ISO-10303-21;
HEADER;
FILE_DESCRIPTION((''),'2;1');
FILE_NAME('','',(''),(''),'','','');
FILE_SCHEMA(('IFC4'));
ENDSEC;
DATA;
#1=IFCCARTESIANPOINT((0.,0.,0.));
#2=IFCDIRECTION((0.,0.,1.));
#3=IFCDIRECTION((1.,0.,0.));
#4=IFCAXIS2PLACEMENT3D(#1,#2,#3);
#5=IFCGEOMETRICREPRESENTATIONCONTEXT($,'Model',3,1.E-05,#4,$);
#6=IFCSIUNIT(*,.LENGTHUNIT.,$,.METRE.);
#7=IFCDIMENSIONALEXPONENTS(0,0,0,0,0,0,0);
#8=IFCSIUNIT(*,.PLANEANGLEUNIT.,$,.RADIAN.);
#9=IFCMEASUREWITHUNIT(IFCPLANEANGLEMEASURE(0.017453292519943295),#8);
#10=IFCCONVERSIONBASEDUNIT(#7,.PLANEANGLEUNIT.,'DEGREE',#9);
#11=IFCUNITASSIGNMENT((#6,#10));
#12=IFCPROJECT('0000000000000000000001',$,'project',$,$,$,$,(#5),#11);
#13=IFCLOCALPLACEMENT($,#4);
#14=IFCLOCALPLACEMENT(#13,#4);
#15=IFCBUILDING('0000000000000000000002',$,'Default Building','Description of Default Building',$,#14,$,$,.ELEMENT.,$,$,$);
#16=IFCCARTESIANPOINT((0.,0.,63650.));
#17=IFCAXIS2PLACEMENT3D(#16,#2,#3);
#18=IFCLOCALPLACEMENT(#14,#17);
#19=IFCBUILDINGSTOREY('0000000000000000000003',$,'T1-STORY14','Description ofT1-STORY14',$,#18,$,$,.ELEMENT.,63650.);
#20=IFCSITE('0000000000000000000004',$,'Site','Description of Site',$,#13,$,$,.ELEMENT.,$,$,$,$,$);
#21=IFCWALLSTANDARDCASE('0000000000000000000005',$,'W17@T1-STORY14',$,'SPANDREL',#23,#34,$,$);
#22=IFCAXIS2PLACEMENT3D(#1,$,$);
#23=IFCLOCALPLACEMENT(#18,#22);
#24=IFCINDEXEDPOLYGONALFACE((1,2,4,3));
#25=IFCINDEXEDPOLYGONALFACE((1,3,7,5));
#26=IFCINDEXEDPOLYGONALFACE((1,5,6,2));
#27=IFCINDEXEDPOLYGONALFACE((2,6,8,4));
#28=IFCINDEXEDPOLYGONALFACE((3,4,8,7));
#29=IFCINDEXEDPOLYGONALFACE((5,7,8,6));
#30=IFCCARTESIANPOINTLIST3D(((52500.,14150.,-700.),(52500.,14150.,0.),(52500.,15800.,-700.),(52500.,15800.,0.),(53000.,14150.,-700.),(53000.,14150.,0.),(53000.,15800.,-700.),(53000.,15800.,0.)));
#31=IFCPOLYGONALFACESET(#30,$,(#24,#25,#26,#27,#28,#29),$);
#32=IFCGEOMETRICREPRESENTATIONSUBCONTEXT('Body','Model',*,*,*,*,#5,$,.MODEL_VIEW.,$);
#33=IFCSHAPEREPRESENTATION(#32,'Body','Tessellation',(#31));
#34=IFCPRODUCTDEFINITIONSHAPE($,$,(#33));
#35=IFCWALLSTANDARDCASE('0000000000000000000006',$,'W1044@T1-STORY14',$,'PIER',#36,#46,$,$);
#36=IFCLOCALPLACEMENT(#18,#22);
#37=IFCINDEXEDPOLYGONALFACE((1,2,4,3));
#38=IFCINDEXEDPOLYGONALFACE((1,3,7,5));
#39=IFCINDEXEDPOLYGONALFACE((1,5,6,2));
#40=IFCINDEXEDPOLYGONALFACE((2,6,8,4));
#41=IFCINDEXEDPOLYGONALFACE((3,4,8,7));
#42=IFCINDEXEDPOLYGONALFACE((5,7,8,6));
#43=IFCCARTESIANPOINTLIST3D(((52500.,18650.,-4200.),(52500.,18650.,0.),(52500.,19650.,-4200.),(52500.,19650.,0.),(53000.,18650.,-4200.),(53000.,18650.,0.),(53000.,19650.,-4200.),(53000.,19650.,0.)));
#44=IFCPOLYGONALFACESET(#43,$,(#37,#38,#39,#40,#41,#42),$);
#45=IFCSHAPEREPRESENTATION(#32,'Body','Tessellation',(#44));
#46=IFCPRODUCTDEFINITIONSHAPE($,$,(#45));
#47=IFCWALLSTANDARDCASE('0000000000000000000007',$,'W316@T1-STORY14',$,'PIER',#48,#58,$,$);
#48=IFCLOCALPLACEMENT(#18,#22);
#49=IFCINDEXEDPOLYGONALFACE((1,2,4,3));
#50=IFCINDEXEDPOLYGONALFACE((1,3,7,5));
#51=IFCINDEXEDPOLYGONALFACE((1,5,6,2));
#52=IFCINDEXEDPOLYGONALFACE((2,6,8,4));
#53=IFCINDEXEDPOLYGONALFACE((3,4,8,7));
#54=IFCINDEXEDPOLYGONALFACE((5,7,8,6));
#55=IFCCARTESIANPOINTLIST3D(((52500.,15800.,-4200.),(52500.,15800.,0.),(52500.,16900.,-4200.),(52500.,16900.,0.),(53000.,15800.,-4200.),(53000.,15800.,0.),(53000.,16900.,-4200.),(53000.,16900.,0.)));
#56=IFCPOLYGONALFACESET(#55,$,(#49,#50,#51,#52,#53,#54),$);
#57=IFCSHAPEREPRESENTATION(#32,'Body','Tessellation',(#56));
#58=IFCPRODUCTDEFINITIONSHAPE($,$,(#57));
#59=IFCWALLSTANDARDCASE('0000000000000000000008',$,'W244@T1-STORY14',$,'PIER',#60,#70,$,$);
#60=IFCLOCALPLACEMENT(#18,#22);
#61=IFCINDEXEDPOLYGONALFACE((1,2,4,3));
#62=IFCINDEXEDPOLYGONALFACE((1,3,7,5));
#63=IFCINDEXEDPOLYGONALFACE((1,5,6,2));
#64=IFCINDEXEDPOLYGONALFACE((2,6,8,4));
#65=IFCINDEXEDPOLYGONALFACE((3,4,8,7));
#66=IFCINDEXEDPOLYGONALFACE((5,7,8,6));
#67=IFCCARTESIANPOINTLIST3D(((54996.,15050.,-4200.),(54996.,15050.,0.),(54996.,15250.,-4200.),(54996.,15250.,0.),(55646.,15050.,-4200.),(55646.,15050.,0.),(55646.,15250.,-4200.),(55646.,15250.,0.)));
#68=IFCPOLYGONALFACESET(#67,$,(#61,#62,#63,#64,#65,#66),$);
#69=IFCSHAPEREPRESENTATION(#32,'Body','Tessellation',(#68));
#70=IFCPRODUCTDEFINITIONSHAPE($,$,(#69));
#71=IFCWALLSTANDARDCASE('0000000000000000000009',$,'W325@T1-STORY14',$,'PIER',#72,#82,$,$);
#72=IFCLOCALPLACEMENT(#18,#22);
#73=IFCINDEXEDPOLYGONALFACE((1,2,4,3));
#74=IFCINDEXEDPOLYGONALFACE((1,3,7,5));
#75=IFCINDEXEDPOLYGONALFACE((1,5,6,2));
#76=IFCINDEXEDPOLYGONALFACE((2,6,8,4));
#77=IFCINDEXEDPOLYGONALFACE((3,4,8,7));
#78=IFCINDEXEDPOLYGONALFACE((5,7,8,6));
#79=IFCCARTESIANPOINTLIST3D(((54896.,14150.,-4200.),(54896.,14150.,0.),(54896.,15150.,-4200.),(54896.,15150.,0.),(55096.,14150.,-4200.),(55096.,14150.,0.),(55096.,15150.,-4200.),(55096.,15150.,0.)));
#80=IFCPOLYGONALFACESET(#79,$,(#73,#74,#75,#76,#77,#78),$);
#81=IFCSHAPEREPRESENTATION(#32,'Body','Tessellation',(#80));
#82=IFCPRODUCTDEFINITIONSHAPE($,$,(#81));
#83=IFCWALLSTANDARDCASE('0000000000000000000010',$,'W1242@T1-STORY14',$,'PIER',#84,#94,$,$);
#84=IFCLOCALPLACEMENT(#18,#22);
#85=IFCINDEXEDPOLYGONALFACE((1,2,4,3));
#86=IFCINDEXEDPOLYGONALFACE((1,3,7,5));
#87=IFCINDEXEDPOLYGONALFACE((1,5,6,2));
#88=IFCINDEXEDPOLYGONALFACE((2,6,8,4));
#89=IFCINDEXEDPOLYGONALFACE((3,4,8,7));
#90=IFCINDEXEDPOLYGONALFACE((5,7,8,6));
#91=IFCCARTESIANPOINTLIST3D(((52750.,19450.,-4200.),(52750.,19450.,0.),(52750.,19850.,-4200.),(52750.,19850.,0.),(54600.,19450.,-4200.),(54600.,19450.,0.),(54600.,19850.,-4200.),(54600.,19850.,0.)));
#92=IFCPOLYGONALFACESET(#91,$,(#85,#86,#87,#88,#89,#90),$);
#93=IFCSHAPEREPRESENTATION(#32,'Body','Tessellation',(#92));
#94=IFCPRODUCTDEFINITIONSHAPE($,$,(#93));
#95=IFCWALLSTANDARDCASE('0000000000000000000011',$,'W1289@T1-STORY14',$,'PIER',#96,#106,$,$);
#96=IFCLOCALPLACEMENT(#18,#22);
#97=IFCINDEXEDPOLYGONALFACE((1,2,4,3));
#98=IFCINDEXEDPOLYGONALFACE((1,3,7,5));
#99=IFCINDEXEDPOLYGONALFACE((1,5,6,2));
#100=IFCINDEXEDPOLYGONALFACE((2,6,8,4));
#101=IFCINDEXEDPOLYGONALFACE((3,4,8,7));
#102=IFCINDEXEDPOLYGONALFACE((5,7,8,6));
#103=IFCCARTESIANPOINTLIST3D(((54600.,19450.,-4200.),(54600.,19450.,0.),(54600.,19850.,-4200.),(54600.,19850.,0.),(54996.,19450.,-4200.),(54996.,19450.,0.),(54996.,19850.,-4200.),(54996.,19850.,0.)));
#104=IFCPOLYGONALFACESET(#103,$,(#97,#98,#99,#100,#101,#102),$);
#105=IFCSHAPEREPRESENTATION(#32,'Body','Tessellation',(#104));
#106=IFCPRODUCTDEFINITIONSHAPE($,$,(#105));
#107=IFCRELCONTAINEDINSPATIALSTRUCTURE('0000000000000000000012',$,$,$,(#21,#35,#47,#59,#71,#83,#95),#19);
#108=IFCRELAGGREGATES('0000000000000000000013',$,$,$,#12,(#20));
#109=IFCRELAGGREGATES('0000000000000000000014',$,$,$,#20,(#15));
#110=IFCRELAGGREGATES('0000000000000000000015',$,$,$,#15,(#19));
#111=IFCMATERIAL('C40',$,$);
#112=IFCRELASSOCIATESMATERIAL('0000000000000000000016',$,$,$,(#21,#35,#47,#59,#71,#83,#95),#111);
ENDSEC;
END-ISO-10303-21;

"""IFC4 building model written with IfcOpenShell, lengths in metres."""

from ifc_helpers import new_model, entity, si_unit, converted_unit, frame, origin_with_axes, place, context, subcontext, project, spatial, indexed_curve, outline, extrude, material, element, save


model = new_model("IFC4")

# Units and contexts
model_context = context("Model", 3, precision=1e-05, world=origin_with_axes())
body_context = subcontext(model_context, "Body", "Model", "MODEL_VIEW")
ifc_project = project(units=[si_unit("LENGTHUNIT", "METRE"), converted_unit("PLANEANGLEUNIT", "DEGREE", entity("IfcPlaneAngleMeasure", 0.017453292519943295), si_unit("PLANEANGLEUNIT", "RADIAN"), dimensions=[0, 0, 0, 0, 0, 0, 0])], contexts=[model_context])

# Site, building, storey
site_placement = place(None, origin_with_axes())
site = spatial("IfcSite", under=ifc_project, at=site_placement, Name="Site", Description="Description of Site", CompositionType="ELEMENT")
building_placement = place(site_placement, origin_with_axes())
building = spatial("IfcBuilding", under=site, at=building_placement, Name="Default Building", Description="Description of Default Building", CompositionType="ELEMENT")
storey_placement = place(building_placement, frame((0.0, 0.0, 63650.0), z_axis=(0.0, 0.0, 1.0), x_axis=(1.0, 0.0, 0.0)))
storey = spatial("IfcBuildingStorey", under=building, at=storey_placement, Name="T1-STORY14", Description="Description ofT1-STORY14", CompositionType="ELEMENT", Elevation=63650.0)

# Shared definitions
ifc_material_1 = material(Name="C40")

# Walls
wall_1_placement = place(storey_placement, frame((52750.0, 14150.0, -700.0), z_axis=(0.0, 0.0, 1.0), x_axis=(0.0, 1.0, 0.0)))
element("IfcWallStandardCase", 1, at=wall_1_placement, inside=storey, material=ifc_material_1, Name="W17@T1-STORY14", ObjectType="SPANDREL", context=body_context, shape_type="SweptSolid", body=[
    extrude(outline(indexed_curve([(0.0, -250.0), (0.0, 250.0), (1650.0, 250.0), (1650.0, -250.0), (0.0, -250.0)], self_intersect=False)), origin_with_axes(), (0.0, 0.0, 1.0), 700.0),
])
wall_2_placement = place(storey_placement, frame((52750.0, 18650.0, -4200.0), z_axis=(0.0, 0.0, 1.0), x_axis=(0.0, 1.0, 0.0)))
element("IfcWallStandardCase", 2, at=wall_2_placement, inside=storey, material=ifc_material_1, Name="W1044@T1-STORY14", ObjectType="PIER", context=body_context, shape_type="SweptSolid", body=[
    extrude(outline(indexed_curve([(0.0, -250.0), (0.0, 250.0), (1000.0, 250.0), (1000.0, -250.0), (0.0, -250.0)], self_intersect=False)), origin_with_axes(), (0.0, 0.0, 1.0), 4200.0),
])
wall_3_placement = place(storey_placement, frame((52750.0, 15800.0, -4200.0), z_axis=(0.0, 0.0, 1.0), x_axis=(0.0, 1.0, 0.0)))
element("IfcWallStandardCase", 3, at=wall_3_placement, inside=storey, material=ifc_material_1, Name="W316@T1-STORY14", ObjectType="PIER", context=body_context, shape_type="SweptSolid", body=[
    extrude(outline(indexed_curve([(0.0, -250.0), (0.0, 250.0), (1100.0, 250.0), (1100.0, -250.0), (0.0, -250.0)], self_intersect=False)), origin_with_axes(), (0.0, 0.0, 1.0), 4200.0),
])
wall_4_placement = place(storey_placement, frame((54996.0, 15150.0, -4200.0), z_axis=(0.0, 0.0, 1.0), x_axis=(1.0, 0.0, 0.0)))
element("IfcWallStandardCase", 4, at=wall_4_placement, inside=storey, material=ifc_material_1, Name="W244@T1-STORY14", ObjectType="PIER", context=body_context, shape_type="SweptSolid", body=[
    extrude(outline(indexed_curve([(0.0, -100.0), (0.0, 100.0), (650.0, 100.0), (650.0, -100.0), (0.0, -100.0)], self_intersect=False)), origin_with_axes(), (0.0, 0.0, 1.0), 4200.0),
])
wall_5_placement = place(storey_placement, frame((54996.0, 14150.0, -4200.0), z_axis=(0.0, 0.0, 1.0), x_axis=(0.0, 1.0, 0.0)))
element("IfcWallStandardCase", 5, at=wall_5_placement, inside=storey, material=ifc_material_1, Name="W325@T1-STORY14", ObjectType="PIER", context=body_context, shape_type="SweptSolid", body=[
    extrude(outline(indexed_curve([(0.0, -100.0), (0.0, 100.0), (1000.0, 100.0), (1000.0, -100.0), (0.0, -100.0)], self_intersect=False)), origin_with_axes(), (0.0, 0.0, 1.0), 4200.0),
])
wall_6_placement = place(storey_placement, frame((52750.0, 19650.0, -4200.0), z_axis=(0.0, 0.0, 1.0), x_axis=(1.0, 0.0, 0.0)))
element("IfcWallStandardCase", 6, at=wall_6_placement, inside=storey, material=ifc_material_1, Name="W1242@T1-STORY14", ObjectType="PIER", context=body_context, shape_type="SweptSolid", body=[
    extrude(outline(indexed_curve([(0.0, -200.0), (0.0, 200.0), (1850.0, 200.0), (1850.0, -200.0), (0.0, -200.0)], self_intersect=False)), origin_with_axes(), (0.0, 0.0, 1.0), 4200.0),
])
wall_7_placement = place(storey_placement, frame((54600.0, 19650.0, -4200.0), z_axis=(0.0, 0.0, 1.0), x_axis=(1.0, 0.0, 0.0)))
element("IfcWallStandardCase", 7, at=wall_7_placement, inside=storey, material=ifc_material_1, Name="W1289@T1-STORY14", ObjectType="PIER", context=body_context, shape_type="SweptSolid", body=[
    extrude(outline(indexed_curve([(0.0, -200.0), (0.0, 200.0), (396.0, 200.0), (396.0, -200.0), (0.0, -200.0)], self_intersect=False)), origin_with_axes(), (0.0, 0.0, 1.0), 4200.0),
])

save(model, "model.ifc")
